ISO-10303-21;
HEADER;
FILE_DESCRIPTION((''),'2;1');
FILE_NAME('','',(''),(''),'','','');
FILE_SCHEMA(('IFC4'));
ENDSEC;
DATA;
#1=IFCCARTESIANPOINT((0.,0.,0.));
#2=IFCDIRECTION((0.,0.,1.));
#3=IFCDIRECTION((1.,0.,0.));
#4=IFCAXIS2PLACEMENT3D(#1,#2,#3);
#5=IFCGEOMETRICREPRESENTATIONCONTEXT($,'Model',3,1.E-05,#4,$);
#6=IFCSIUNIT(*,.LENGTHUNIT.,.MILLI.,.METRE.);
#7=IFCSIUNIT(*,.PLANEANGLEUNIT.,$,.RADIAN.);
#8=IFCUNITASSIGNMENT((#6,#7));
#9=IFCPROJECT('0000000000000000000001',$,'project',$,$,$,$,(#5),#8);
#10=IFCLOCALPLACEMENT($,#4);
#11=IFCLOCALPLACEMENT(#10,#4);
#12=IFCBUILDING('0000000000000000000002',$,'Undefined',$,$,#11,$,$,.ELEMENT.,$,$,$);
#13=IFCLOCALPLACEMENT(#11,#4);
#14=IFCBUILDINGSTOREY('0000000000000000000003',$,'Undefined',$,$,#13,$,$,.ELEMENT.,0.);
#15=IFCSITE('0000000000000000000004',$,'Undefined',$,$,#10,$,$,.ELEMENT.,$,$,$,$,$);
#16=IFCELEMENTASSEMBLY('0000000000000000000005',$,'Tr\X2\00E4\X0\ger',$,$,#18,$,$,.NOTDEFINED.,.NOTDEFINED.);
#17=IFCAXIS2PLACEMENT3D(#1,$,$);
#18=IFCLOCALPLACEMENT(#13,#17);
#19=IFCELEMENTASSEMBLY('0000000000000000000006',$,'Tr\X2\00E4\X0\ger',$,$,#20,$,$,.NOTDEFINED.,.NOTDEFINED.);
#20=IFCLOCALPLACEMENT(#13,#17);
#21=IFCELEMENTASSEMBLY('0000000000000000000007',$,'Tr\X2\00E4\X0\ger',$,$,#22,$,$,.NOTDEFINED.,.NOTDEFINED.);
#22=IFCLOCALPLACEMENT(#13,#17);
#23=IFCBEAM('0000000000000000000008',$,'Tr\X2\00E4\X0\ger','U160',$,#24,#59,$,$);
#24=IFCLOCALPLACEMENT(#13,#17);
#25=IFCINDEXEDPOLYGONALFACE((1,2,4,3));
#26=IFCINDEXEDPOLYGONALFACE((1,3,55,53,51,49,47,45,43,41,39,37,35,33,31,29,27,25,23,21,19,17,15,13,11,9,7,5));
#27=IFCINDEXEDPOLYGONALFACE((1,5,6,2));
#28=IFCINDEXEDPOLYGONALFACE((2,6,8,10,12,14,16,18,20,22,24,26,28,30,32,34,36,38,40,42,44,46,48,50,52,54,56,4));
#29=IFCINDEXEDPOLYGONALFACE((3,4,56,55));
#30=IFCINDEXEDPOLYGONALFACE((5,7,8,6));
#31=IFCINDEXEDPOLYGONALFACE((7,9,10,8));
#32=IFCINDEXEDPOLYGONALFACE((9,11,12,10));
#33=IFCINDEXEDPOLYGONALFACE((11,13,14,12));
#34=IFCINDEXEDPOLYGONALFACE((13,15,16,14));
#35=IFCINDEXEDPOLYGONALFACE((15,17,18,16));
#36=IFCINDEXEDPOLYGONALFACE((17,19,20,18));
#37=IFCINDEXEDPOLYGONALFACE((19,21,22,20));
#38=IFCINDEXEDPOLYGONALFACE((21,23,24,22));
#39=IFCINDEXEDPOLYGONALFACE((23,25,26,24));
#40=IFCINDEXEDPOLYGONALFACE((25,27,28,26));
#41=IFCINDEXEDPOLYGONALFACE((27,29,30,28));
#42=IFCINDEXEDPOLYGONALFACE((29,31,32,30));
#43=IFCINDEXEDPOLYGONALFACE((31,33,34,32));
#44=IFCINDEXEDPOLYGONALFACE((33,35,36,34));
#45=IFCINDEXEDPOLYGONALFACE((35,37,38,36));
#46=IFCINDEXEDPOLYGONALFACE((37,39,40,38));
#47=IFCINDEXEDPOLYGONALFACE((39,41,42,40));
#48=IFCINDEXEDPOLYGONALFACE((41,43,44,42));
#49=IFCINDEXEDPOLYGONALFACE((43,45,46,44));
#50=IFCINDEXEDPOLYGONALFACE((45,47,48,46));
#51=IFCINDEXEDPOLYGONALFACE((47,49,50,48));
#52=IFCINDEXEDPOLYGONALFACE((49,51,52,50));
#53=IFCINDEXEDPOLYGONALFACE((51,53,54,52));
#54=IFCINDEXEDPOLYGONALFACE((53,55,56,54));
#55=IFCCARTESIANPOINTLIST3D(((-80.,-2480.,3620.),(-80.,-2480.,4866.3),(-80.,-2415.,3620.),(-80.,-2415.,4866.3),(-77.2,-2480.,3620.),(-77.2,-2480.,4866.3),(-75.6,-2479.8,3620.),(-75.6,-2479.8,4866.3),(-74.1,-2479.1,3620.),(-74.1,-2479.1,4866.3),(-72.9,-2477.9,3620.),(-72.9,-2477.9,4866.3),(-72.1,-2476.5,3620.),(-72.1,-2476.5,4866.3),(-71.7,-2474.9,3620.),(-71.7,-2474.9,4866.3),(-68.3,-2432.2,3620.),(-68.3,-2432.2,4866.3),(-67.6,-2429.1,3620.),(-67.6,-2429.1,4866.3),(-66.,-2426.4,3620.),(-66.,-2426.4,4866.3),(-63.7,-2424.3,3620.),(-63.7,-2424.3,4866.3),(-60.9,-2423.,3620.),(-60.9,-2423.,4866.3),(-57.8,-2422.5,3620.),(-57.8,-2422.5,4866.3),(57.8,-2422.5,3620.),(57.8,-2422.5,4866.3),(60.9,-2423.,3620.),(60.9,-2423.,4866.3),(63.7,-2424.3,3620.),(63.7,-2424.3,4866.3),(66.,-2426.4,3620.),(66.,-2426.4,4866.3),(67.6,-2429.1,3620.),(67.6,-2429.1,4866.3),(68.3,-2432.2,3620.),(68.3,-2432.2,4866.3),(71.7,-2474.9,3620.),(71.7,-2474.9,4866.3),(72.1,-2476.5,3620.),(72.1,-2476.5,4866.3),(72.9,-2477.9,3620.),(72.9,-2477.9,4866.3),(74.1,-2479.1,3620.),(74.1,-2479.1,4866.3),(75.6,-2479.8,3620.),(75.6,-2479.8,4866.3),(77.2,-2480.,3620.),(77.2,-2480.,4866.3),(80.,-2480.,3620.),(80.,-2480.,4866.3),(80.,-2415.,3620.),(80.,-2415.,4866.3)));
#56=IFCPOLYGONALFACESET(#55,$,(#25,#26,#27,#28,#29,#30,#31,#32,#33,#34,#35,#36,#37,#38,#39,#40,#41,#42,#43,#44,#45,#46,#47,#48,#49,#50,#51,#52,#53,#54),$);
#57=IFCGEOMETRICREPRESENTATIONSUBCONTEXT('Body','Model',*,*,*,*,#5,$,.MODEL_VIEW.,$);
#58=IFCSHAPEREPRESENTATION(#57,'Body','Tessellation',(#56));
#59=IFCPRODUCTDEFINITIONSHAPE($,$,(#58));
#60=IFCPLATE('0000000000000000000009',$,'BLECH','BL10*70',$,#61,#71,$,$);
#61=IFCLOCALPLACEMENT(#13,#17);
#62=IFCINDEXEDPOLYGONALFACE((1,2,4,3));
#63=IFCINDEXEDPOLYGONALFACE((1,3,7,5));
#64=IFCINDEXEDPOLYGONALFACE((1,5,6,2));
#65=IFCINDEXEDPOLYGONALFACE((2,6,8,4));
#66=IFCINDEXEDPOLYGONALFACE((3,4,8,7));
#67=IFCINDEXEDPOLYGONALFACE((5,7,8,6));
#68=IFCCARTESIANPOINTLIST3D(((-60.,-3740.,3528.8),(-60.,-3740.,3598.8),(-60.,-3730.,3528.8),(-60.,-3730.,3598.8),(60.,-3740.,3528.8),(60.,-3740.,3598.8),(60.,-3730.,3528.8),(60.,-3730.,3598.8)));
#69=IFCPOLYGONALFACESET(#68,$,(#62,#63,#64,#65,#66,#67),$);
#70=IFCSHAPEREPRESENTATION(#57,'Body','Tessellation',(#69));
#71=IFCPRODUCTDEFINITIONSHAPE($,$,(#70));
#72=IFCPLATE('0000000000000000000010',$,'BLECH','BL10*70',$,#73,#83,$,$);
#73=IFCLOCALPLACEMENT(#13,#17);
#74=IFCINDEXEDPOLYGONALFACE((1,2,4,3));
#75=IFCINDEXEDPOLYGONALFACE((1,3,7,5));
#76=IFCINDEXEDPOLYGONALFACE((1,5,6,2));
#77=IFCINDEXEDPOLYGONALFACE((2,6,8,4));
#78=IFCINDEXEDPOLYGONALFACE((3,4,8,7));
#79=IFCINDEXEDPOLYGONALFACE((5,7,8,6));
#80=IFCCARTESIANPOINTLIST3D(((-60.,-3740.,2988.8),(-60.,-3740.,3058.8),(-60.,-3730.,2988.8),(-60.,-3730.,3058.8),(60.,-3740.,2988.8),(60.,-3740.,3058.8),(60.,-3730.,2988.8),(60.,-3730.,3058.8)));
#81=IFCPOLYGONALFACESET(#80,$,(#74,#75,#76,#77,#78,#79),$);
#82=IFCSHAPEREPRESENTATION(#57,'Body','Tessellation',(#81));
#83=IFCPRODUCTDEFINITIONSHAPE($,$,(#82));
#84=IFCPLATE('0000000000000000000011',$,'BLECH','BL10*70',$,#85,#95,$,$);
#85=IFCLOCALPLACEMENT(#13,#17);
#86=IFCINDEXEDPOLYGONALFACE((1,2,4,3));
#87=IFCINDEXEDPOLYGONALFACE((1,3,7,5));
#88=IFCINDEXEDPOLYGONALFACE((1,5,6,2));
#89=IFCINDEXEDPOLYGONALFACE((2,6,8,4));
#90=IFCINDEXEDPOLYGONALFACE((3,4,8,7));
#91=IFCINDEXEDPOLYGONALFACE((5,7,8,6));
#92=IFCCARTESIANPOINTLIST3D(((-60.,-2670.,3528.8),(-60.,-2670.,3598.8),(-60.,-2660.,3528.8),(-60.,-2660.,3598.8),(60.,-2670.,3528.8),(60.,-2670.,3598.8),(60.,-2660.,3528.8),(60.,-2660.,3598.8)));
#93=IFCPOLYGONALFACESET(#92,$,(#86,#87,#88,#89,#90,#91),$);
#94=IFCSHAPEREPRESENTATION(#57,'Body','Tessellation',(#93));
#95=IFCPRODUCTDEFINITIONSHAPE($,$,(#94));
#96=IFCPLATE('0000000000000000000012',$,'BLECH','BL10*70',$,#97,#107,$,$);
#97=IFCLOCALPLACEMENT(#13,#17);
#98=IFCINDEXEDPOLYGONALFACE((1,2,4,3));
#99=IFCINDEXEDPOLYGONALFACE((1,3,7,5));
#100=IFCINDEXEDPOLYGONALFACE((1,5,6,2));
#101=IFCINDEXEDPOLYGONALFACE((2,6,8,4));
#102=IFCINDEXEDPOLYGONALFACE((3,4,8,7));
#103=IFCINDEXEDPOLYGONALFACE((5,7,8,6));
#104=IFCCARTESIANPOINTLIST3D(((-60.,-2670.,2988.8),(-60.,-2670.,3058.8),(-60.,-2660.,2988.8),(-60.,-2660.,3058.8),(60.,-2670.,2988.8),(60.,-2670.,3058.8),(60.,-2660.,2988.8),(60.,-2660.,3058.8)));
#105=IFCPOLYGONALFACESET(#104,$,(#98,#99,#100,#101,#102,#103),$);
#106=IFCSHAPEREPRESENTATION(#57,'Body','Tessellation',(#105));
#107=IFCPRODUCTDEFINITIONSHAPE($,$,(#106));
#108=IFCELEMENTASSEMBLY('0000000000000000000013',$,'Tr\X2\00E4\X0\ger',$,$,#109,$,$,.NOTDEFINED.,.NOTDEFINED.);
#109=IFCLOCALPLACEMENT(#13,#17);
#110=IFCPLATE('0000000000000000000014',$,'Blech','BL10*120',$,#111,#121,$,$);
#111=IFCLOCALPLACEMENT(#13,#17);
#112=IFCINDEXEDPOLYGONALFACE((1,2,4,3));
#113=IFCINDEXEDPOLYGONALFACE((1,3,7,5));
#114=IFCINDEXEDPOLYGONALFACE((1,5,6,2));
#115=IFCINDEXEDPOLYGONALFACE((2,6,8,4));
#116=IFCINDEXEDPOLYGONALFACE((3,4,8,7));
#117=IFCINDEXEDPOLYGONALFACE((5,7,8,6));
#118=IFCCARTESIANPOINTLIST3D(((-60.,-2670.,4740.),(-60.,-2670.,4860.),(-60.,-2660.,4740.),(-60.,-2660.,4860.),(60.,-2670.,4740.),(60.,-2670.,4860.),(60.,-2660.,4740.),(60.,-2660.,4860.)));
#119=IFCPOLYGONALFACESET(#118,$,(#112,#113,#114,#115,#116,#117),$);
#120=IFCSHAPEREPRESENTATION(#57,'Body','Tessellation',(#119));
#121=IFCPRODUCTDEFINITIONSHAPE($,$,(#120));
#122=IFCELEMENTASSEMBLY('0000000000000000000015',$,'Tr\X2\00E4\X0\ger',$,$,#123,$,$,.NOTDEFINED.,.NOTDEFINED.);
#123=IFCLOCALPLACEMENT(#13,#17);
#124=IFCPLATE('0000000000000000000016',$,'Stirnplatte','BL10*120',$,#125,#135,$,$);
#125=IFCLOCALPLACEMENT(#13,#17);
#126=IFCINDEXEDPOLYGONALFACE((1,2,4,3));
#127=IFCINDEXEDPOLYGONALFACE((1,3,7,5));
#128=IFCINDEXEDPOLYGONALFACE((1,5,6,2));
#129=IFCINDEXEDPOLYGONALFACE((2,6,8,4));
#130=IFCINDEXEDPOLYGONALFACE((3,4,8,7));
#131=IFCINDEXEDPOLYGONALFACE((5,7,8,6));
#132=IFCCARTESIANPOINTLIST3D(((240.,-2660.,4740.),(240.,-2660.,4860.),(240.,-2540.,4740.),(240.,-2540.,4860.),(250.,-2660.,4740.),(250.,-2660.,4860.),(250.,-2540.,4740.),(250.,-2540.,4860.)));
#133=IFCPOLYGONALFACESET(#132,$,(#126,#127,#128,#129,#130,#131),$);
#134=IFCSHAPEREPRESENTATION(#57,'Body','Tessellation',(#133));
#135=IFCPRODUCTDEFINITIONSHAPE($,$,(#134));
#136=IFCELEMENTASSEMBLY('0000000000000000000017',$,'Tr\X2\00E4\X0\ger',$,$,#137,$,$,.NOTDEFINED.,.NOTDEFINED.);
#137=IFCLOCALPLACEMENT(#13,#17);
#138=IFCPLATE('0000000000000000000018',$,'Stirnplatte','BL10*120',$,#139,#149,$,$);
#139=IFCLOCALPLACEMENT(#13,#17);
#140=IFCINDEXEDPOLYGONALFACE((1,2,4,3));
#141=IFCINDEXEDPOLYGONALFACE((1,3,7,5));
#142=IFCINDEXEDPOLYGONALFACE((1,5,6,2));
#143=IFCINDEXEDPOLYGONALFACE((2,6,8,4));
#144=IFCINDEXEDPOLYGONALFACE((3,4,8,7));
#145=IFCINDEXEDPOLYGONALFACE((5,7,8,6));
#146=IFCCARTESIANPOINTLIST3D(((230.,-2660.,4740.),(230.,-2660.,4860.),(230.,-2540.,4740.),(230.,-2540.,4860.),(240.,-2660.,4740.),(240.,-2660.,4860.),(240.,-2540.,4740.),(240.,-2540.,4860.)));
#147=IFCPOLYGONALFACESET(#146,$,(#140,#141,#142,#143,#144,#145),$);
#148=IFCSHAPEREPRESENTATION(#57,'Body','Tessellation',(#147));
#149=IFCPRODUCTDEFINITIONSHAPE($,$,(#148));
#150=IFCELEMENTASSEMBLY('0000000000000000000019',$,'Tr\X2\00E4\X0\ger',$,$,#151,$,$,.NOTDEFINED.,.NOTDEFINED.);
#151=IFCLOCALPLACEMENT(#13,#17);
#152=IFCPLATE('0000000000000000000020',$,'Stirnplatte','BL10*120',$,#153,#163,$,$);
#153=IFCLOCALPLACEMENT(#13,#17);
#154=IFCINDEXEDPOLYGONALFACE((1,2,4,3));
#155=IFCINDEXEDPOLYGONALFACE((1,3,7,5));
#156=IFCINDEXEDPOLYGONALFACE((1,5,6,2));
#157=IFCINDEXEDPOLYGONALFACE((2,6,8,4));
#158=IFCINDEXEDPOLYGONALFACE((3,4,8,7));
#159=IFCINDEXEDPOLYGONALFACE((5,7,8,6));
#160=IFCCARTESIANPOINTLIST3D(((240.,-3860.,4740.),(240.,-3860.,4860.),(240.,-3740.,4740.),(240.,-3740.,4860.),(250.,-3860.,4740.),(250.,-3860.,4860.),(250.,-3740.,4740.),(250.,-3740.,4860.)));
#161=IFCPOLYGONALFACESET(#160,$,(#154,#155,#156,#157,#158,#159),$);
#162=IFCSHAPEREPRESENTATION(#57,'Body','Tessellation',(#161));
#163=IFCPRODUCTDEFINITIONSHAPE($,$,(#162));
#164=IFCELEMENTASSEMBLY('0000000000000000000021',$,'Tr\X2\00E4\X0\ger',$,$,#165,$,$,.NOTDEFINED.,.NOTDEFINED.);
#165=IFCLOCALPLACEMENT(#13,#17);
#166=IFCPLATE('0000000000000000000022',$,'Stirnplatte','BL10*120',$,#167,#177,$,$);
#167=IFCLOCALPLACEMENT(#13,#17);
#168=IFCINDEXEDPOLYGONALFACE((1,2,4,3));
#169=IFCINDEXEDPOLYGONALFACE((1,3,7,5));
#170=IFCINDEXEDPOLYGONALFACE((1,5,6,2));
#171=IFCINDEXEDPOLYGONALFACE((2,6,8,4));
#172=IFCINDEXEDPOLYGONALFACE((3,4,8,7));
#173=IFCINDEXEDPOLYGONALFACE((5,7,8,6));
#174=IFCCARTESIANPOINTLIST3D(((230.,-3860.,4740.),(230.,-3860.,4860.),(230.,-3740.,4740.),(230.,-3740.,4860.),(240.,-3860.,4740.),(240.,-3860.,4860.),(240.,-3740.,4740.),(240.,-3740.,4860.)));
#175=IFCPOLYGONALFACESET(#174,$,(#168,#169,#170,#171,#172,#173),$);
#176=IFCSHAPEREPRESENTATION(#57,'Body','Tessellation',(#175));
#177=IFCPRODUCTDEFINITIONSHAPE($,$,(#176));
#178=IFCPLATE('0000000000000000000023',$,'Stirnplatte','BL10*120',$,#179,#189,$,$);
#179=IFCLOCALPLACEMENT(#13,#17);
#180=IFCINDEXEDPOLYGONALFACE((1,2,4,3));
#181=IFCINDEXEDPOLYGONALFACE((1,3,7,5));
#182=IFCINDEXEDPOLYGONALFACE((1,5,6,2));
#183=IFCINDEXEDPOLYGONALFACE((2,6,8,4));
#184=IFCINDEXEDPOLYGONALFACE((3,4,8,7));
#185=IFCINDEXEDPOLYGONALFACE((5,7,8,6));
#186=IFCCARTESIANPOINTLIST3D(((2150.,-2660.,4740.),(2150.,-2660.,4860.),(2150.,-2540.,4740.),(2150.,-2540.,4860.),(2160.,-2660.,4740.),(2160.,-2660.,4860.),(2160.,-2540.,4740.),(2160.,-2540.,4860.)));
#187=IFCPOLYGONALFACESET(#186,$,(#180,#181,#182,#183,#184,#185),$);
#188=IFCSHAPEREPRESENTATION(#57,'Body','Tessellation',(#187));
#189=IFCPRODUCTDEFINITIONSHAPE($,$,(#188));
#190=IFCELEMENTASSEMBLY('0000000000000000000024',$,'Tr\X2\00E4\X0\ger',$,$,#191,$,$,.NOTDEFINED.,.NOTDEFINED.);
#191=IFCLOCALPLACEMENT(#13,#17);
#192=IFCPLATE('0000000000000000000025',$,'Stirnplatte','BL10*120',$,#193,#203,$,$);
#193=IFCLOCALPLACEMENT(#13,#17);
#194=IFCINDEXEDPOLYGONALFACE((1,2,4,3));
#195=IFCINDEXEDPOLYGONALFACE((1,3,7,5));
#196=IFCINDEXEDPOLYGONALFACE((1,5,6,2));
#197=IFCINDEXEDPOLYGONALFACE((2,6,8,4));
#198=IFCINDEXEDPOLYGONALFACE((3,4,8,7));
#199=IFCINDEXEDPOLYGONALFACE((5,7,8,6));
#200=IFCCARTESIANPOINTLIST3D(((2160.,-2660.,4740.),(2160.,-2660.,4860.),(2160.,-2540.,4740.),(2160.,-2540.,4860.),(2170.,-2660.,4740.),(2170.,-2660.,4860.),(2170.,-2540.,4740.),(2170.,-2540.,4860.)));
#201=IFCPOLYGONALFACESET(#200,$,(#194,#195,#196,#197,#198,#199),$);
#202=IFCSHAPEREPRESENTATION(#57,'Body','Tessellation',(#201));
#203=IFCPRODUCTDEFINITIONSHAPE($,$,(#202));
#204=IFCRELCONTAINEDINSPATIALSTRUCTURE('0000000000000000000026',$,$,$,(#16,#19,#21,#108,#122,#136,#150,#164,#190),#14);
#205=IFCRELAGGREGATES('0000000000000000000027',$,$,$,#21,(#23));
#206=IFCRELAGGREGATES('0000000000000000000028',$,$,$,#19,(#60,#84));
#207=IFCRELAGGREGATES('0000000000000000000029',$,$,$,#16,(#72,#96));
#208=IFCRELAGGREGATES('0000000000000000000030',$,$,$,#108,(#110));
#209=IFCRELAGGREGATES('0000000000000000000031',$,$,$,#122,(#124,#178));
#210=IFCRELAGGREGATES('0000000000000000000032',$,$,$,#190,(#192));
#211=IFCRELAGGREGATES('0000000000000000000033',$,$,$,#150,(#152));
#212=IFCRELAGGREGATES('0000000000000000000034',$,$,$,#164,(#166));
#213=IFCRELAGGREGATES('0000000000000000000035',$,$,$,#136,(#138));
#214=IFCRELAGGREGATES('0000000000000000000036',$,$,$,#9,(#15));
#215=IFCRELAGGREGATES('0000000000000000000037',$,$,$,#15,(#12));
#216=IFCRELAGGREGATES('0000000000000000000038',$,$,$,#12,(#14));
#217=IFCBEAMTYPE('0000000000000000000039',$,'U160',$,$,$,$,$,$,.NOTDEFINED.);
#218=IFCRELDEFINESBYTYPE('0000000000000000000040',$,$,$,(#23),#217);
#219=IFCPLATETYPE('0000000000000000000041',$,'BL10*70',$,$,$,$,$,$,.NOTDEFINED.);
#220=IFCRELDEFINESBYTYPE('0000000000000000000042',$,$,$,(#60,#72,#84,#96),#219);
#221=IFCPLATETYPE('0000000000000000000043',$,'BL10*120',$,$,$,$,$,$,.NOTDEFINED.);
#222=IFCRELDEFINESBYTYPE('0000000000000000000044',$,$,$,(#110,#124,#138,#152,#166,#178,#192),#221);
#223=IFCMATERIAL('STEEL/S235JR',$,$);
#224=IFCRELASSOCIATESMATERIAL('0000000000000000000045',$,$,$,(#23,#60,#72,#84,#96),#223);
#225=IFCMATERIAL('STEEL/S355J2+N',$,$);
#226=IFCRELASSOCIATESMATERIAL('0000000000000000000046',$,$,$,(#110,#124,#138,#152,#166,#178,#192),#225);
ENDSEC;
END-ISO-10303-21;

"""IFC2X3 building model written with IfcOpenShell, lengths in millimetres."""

from ifc_helpers import new_model, si_unit, frame, origin_with_axes, origin_2d_with_axis, place, context, subcontext, project, spatial, polyline, u_section, outline, extrude, material, type_object, element, aggregate, save


model = new_model("IFC2X3")

# Units and contexts
model_context = context("Model", 3, precision=1e-05, world=origin_with_axes())
body_context = subcontext(model_context, "Body", "Model", "MODEL_VIEW")
ifc_project = project(units=[si_unit("LENGTHUNIT", "METRE", prefix="MILLI"), si_unit("PLANEANGLEUNIT", "RADIAN")], contexts=[model_context])

# Site, building, storey
site_placement = place(None, origin_with_axes())
site = spatial("IfcSite", under=ifc_project, at=site_placement, Name="Undefined", CompositionType="ELEMENT")
building_placement = place(site_placement, origin_with_axes())
building = spatial("IfcBuilding", under=site, at=building_placement, Name="Undefined", CompositionType="ELEMENT")
storey_placement = place(building_placement, origin_with_axes())
storey = spatial("IfcBuildingStorey", under=building, at=storey_placement, Name="Undefined", CompositionType="ELEMENT", Elevation=0.0)

# Element assemblies
assembly_1_placement = place(storey_placement, origin_with_axes())
assembly_1 = element("IfcElementAssembly", 1, at=assembly_1_placement, inside=storey, Name="Träger", AssemblyPlace="NOTDEFINED", PredefinedType="NOTDEFINED")
ifc_material_1 = material(Name="STEEL/S235JR")
assembly_2_placement = place(storey_placement, origin_with_axes())
assembly_2 = element("IfcElementAssembly", 2, at=assembly_2_placement, inside=storey, Name="Träger", AssemblyPlace="NOTDEFINED", PredefinedType="NOTDEFINED")

# Element assembly, beam
assembly_3_placement = place(storey_placement, origin_with_axes())
assembly_3 = element("IfcElementAssembly", 3, at=assembly_3_placement, inside=storey, Name="Träger", AssemblyPlace="NOTDEFINED", PredefinedType="NOTDEFINED")
beam_type_1 = type_object("IfcBeamType", Name="U160", PredefinedType="NOTDEFINED")
beam_1_placement = place(assembly_3_placement, frame((0.0, -2447.5, 3620.0), z_axis=(-1.0, 0.0, 0.0), x_axis=(0.0, 0.0, 1.0)))
beam_1 = element("IfcBeam", 4, at=beam_1_placement, type_object=beam_type_1, material=ifc_material_1, Name="Träger", Description="U160", context=body_context, shape_type="SweptSolid", body=[
    extrude(u_section(Depth=160.0, FlangeWidth=65.0, WebThickness=7.5, FlangeThickness=10.5, FilletRadius=10.5, EdgeRadius=5.5, FlangeSlope=0.07983, at=origin_2d_with_axis()), frame((1246.3, 0.0, 0.0), z_axis=(-1.0, 0.0, 0.0), x_axis=(0.0, -1.0, 0.0)), (0.0, 0.0, 1.0), 1246.3),
])
aggregate(assembly_3, [beam_1])

# Plates
plate_type_1 = type_object("IfcPlateType", Name="BL10*70", PredefinedType="NOTDEFINED")
plate_1_placement = place(assembly_2_placement, frame((60.0, -3735.0, 3598.8), z_axis=(0.0, -1.0, 0.0), x_axis=(-1.0, 0.0, 0.0)))
plate_1 = element("IfcPlate", 5, at=plate_1_placement, type_object=plate_type_1, material=ifc_material_1, Name="BLECH", Description="BL10*70", context=body_context, shape_type="SweptSolid", body=[
    extrude(outline(polyline([(0.0, 0.0), (120.0, 0.0), (120.0, 70.0), (0.0, 70.0), (0.0, 0.0)])), frame((0.0, 0.0, -5.0), z_axis=(0.0, 0.0, 1.0), x_axis=(1.0, 0.0, 0.0)), (0.0, 0.0, 1.0), 10.0),
])
plate_2_placement = place(assembly_1_placement, frame((60.0, -3735.0, 3058.8), z_axis=(0.0, -1.0, 0.0), x_axis=(-1.0, 0.0, 0.0)))
plate_2 = element("IfcPlate", 6, at=plate_2_placement, type_object=plate_type_1, material=ifc_material_1, Name="BLECH", Description="BL10*70", context=body_context, shape_type="SweptSolid", body=[
    extrude(outline(polyline([(0.0, 0.0), (120.0, 0.0), (120.0, 70.0), (0.0, 70.0), (0.0, 0.0)])), frame((0.0, 0.0, -5.0), z_axis=(0.0, 0.0, 1.0), x_axis=(1.0, 0.0, 0.0)), (0.0, 0.0, 1.0), 10.0),
])
plate_3_placement = place(assembly_2_placement, frame((60.0, -2665.0, 3598.8), z_axis=(0.0, -1.0, 0.0), x_axis=(-1.0, 0.0, 0.0)))
plate_3 = element("IfcPlate", 7, at=plate_3_placement, type_object=plate_type_1, material=ifc_material_1, Name="BLECH", Description="BL10*70", context=body_context, shape_type="SweptSolid", body=[
    extrude(outline(polyline([(0.0, 0.0), (120.0, 0.0), (120.0, 70.0), (0.0, 70.0), (0.0, 0.0)])), frame((0.0, 0.0, -5.0), z_axis=(0.0, 0.0, 1.0), x_axis=(1.0, 0.0, 0.0)), (0.0, 0.0, 1.0), 10.0),
])
aggregate(assembly_2, [plate_1, plate_3])
plate_4_placement = place(assembly_1_placement, frame((60.0, -2665.0, 3058.8), z_axis=(0.0, -1.0, 0.0), x_axis=(-1.0, 0.0, 0.0)))
plate_4 = element("IfcPlate", 8, at=plate_4_placement, type_object=plate_type_1, material=ifc_material_1, Name="BLECH", Description="BL10*70", context=body_context, shape_type="SweptSolid", body=[
    extrude(outline(polyline([(0.0, 0.0), (120.0, 0.0), (120.0, 70.0), (0.0, 70.0), (0.0, 0.0)])), frame((0.0, 0.0, -5.0), z_axis=(0.0, 0.0, 1.0), x_axis=(1.0, 0.0, 0.0)), (0.0, 0.0, 1.0), 10.0),
])
aggregate(assembly_1, [plate_2, plate_4])

# Element assemblies, plates
assembly_4_placement = place(storey_placement, origin_with_axes())
assembly_4 = element("IfcElementAssembly", 9, at=assembly_4_placement, inside=storey, Name="Träger", AssemblyPlace="NOTDEFINED", PredefinedType="NOTDEFINED")
ifc_material_2 = material(Name="STEEL/S355J2+N")
plate_type_2 = type_object("IfcPlateType", Name="BL10*120", PredefinedType="NOTDEFINED")
plate_5_placement = place(assembly_4_placement, frame((0.0, -2665.0, 4740.0), z_axis=(0.0, -1.0, 0.0), x_axis=(0.0, 0.0, 1.0)))
plate_5 = element("IfcPlate", 10, at=plate_5_placement, type_object=plate_type_2, material=ifc_material_2, Name="Blech", Description="BL10*120", context=body_context, shape_type="SweptSolid", body=[
    extrude(outline(polyline([(0.0, -60.0), (0.0, 60.0), (120.0, 60.0), (120.0, -60.0), (0.0, -60.0)])), frame((0.0, 0.0, -5.0), z_axis=(0.0, 0.0, 1.0), x_axis=(1.0, 0.0, 0.0)), (0.0, 0.0, 1.0), 10.0),
])
aggregate(assembly_4, [plate_5])
assembly_5_placement = place(storey_placement, origin_with_axes())
assembly_5 = element("IfcElementAssembly", 11, at=assembly_5_placement, inside=storey, Name="Träger", AssemblyPlace="NOTDEFINED", PredefinedType="NOTDEFINED")
plate_6_placement = place(assembly_5_placement, frame((245.0, -2600.0, 4740.0), z_axis=(1.0, 0.0, 0.0), x_axis=(0.0, 0.0, 1.0)))
plate_6 = element("IfcPlate", 12, at=plate_6_placement, type_object=plate_type_2, material=ifc_material_2, Name="Stirnplatte", Description="BL10*120", context=body_context, shape_type="SweptSolid", body=[
    extrude(outline(polyline([(0.0, -60.0), (0.0, 60.0), (120.0, 60.0), (120.0, -60.0), (0.0, -60.0)])), frame((0.0, 0.0, -5.0), z_axis=(0.0, 0.0, 1.0), x_axis=(1.0, 0.0, 0.0)), (0.0, 0.0, 1.0), 10.0),
])
assembly_6_placement = place(storey_placement, origin_with_axes())
assembly_6 = element("IfcElementAssembly", 13, at=assembly_6_placement, inside=storey, Name="Träger", AssemblyPlace="NOTDEFINED", PredefinedType="NOTDEFINED")
plate_7_placement = place(assembly_6_placement, frame((235.0, -2600.0, 4740.0), z_axis=(1.0, 0.0, 0.0), x_axis=(0.0, 0.0, 1.0)))
plate_7 = element("IfcPlate", 14, at=plate_7_placement, type_object=plate_type_2, material=ifc_material_2, Name="Stirnplatte", Description="BL10*120", context=body_context, shape_type="SweptSolid", body=[
    extrude(outline(polyline([(0.0, -60.0), (0.0, 60.0), (120.0, 60.0), (120.0, -60.0), (0.0, -60.0)])), frame((0.0, 0.0, -5.0), z_axis=(0.0, 0.0, 1.0), x_axis=(1.0, 0.0, 0.0)), (0.0, 0.0, 1.0), 10.0),
])
assembly_7_placement = place(storey_placement, origin_with_axes())
assembly_7 = element("IfcElementAssembly", 15, at=assembly_7_placement, inside=storey, Name="Träger", AssemblyPlace="NOTDEFINED", PredefinedType="NOTDEFINED")
plate_8_placement = place(assembly_7_placement, frame((245.0, -3800.0, 4740.0), z_axis=(1.0, 0.0, 0.0), x_axis=(0.0, 0.0, 1.0)))
plate_8 = element("IfcPlate", 16, at=plate_8_placement, type_object=plate_type_2, material=ifc_material_2, Name="Stirnplatte", Description="BL10*120", context=body_context, shape_type="SweptSolid", body=[
    extrude(outline(polyline([(0.0, -60.0), (0.0, 60.0), (120.0, 60.0), (120.0, -60.0), (0.0, -60.0)])), frame((0.0, 0.0, -5.0), z_axis=(0.0, 0.0, 1.0), x_axis=(1.0, 0.0, 0.0)), (0.0, 0.0, 1.0), 10.0),
])
assembly_8_placement = place(storey_placement, origin_with_axes())
assembly_8 = element("IfcElementAssembly", 17, at=assembly_8_placement, inside=storey, Name="Träger", AssemblyPlace="NOTDEFINED", PredefinedType="NOTDEFINED")
plate_9_placement = place(assembly_8_placement, frame((235.0, -3800.0, 4740.0), z_axis=(1.0, 0.0, 0.0), x_axis=(0.0, 0.0, 1.0)))
plate_9 = element("IfcPlate", 18, at=plate_9_placement, type_object=plate_type_2, material=ifc_material_2, Name="Stirnplatte", Description="BL10*120", context=body_context, shape_type="SweptSolid", body=[
    extrude(outline(polyline([(0.0, -60.0), (0.0, 60.0), (120.0, 60.0), (120.0, -60.0), (0.0, -60.0)])), frame((0.0, 0.0, -5.0), z_axis=(0.0, 0.0, 1.0), x_axis=(1.0, 0.0, 0.0)), (0.0, 0.0, 1.0), 10.0),
])

# Plate
plate_10_placement = place(assembly_5_placement, frame((2155.0, -2600.0, 4740.0), z_axis=(-1.0, 0.0, 0.0), x_axis=(0.0, 0.0, 1.0)))
plate_10 = element("IfcPlate", 19, at=plate_10_placement, type_object=plate_type_2, material=ifc_material_2, Name="Stirnplatte", Description="BL10*120", context=body_context, shape_type="SweptSolid", body=[
    extrude(outline(polyline([(0.0, -60.0), (0.0, 60.0), (120.0, 60.0), (120.0, -60.0), (0.0, -60.0)])), frame((0.0, 0.0, -5.0), z_axis=(0.0, 0.0, 1.0), x_axis=(1.0, 0.0, 0.0)), (0.0, 0.0, 1.0), 10.0),
])
aggregate(assembly_5, [plate_6, plate_10])

# Element assembly, plate
assembly_9_placement = place(storey_placement, origin_with_axes())
assembly_9 = element("IfcElementAssembly", 20, at=assembly_9_placement, inside=storey, Name="Träger", AssemblyPlace="NOTDEFINED", PredefinedType="NOTDEFINED")
plate_11_placement = place(assembly_9_placement, frame((2165.0, -2600.0, 4740.0), z_axis=(-1.0, 0.0, 0.0), x_axis=(0.0, 0.0, 1.0)))
plate_11 = element("IfcPlate", 21, at=plate_11_placement, type_object=plate_type_2, material=ifc_material_2, Name="Stirnplatte", Description="BL10*120", context=body_context, shape_type="SweptSolid", body=[
    extrude(outline(polyline([(0.0, -60.0), (0.0, 60.0), (120.0, 60.0), (120.0, -60.0), (0.0, -60.0)])), frame((0.0, 0.0, -5.0), z_axis=(0.0, 0.0, 1.0), x_axis=(1.0, 0.0, 0.0)), (0.0, 0.0, 1.0), 10.0),
])
aggregate(assembly_9, [plate_11])

aggregate(assembly_7, [plate_8])

aggregate(assembly_8, [plate_9])
aggregate(assembly_6, [plate_7])

save(model, "model.ifc")
